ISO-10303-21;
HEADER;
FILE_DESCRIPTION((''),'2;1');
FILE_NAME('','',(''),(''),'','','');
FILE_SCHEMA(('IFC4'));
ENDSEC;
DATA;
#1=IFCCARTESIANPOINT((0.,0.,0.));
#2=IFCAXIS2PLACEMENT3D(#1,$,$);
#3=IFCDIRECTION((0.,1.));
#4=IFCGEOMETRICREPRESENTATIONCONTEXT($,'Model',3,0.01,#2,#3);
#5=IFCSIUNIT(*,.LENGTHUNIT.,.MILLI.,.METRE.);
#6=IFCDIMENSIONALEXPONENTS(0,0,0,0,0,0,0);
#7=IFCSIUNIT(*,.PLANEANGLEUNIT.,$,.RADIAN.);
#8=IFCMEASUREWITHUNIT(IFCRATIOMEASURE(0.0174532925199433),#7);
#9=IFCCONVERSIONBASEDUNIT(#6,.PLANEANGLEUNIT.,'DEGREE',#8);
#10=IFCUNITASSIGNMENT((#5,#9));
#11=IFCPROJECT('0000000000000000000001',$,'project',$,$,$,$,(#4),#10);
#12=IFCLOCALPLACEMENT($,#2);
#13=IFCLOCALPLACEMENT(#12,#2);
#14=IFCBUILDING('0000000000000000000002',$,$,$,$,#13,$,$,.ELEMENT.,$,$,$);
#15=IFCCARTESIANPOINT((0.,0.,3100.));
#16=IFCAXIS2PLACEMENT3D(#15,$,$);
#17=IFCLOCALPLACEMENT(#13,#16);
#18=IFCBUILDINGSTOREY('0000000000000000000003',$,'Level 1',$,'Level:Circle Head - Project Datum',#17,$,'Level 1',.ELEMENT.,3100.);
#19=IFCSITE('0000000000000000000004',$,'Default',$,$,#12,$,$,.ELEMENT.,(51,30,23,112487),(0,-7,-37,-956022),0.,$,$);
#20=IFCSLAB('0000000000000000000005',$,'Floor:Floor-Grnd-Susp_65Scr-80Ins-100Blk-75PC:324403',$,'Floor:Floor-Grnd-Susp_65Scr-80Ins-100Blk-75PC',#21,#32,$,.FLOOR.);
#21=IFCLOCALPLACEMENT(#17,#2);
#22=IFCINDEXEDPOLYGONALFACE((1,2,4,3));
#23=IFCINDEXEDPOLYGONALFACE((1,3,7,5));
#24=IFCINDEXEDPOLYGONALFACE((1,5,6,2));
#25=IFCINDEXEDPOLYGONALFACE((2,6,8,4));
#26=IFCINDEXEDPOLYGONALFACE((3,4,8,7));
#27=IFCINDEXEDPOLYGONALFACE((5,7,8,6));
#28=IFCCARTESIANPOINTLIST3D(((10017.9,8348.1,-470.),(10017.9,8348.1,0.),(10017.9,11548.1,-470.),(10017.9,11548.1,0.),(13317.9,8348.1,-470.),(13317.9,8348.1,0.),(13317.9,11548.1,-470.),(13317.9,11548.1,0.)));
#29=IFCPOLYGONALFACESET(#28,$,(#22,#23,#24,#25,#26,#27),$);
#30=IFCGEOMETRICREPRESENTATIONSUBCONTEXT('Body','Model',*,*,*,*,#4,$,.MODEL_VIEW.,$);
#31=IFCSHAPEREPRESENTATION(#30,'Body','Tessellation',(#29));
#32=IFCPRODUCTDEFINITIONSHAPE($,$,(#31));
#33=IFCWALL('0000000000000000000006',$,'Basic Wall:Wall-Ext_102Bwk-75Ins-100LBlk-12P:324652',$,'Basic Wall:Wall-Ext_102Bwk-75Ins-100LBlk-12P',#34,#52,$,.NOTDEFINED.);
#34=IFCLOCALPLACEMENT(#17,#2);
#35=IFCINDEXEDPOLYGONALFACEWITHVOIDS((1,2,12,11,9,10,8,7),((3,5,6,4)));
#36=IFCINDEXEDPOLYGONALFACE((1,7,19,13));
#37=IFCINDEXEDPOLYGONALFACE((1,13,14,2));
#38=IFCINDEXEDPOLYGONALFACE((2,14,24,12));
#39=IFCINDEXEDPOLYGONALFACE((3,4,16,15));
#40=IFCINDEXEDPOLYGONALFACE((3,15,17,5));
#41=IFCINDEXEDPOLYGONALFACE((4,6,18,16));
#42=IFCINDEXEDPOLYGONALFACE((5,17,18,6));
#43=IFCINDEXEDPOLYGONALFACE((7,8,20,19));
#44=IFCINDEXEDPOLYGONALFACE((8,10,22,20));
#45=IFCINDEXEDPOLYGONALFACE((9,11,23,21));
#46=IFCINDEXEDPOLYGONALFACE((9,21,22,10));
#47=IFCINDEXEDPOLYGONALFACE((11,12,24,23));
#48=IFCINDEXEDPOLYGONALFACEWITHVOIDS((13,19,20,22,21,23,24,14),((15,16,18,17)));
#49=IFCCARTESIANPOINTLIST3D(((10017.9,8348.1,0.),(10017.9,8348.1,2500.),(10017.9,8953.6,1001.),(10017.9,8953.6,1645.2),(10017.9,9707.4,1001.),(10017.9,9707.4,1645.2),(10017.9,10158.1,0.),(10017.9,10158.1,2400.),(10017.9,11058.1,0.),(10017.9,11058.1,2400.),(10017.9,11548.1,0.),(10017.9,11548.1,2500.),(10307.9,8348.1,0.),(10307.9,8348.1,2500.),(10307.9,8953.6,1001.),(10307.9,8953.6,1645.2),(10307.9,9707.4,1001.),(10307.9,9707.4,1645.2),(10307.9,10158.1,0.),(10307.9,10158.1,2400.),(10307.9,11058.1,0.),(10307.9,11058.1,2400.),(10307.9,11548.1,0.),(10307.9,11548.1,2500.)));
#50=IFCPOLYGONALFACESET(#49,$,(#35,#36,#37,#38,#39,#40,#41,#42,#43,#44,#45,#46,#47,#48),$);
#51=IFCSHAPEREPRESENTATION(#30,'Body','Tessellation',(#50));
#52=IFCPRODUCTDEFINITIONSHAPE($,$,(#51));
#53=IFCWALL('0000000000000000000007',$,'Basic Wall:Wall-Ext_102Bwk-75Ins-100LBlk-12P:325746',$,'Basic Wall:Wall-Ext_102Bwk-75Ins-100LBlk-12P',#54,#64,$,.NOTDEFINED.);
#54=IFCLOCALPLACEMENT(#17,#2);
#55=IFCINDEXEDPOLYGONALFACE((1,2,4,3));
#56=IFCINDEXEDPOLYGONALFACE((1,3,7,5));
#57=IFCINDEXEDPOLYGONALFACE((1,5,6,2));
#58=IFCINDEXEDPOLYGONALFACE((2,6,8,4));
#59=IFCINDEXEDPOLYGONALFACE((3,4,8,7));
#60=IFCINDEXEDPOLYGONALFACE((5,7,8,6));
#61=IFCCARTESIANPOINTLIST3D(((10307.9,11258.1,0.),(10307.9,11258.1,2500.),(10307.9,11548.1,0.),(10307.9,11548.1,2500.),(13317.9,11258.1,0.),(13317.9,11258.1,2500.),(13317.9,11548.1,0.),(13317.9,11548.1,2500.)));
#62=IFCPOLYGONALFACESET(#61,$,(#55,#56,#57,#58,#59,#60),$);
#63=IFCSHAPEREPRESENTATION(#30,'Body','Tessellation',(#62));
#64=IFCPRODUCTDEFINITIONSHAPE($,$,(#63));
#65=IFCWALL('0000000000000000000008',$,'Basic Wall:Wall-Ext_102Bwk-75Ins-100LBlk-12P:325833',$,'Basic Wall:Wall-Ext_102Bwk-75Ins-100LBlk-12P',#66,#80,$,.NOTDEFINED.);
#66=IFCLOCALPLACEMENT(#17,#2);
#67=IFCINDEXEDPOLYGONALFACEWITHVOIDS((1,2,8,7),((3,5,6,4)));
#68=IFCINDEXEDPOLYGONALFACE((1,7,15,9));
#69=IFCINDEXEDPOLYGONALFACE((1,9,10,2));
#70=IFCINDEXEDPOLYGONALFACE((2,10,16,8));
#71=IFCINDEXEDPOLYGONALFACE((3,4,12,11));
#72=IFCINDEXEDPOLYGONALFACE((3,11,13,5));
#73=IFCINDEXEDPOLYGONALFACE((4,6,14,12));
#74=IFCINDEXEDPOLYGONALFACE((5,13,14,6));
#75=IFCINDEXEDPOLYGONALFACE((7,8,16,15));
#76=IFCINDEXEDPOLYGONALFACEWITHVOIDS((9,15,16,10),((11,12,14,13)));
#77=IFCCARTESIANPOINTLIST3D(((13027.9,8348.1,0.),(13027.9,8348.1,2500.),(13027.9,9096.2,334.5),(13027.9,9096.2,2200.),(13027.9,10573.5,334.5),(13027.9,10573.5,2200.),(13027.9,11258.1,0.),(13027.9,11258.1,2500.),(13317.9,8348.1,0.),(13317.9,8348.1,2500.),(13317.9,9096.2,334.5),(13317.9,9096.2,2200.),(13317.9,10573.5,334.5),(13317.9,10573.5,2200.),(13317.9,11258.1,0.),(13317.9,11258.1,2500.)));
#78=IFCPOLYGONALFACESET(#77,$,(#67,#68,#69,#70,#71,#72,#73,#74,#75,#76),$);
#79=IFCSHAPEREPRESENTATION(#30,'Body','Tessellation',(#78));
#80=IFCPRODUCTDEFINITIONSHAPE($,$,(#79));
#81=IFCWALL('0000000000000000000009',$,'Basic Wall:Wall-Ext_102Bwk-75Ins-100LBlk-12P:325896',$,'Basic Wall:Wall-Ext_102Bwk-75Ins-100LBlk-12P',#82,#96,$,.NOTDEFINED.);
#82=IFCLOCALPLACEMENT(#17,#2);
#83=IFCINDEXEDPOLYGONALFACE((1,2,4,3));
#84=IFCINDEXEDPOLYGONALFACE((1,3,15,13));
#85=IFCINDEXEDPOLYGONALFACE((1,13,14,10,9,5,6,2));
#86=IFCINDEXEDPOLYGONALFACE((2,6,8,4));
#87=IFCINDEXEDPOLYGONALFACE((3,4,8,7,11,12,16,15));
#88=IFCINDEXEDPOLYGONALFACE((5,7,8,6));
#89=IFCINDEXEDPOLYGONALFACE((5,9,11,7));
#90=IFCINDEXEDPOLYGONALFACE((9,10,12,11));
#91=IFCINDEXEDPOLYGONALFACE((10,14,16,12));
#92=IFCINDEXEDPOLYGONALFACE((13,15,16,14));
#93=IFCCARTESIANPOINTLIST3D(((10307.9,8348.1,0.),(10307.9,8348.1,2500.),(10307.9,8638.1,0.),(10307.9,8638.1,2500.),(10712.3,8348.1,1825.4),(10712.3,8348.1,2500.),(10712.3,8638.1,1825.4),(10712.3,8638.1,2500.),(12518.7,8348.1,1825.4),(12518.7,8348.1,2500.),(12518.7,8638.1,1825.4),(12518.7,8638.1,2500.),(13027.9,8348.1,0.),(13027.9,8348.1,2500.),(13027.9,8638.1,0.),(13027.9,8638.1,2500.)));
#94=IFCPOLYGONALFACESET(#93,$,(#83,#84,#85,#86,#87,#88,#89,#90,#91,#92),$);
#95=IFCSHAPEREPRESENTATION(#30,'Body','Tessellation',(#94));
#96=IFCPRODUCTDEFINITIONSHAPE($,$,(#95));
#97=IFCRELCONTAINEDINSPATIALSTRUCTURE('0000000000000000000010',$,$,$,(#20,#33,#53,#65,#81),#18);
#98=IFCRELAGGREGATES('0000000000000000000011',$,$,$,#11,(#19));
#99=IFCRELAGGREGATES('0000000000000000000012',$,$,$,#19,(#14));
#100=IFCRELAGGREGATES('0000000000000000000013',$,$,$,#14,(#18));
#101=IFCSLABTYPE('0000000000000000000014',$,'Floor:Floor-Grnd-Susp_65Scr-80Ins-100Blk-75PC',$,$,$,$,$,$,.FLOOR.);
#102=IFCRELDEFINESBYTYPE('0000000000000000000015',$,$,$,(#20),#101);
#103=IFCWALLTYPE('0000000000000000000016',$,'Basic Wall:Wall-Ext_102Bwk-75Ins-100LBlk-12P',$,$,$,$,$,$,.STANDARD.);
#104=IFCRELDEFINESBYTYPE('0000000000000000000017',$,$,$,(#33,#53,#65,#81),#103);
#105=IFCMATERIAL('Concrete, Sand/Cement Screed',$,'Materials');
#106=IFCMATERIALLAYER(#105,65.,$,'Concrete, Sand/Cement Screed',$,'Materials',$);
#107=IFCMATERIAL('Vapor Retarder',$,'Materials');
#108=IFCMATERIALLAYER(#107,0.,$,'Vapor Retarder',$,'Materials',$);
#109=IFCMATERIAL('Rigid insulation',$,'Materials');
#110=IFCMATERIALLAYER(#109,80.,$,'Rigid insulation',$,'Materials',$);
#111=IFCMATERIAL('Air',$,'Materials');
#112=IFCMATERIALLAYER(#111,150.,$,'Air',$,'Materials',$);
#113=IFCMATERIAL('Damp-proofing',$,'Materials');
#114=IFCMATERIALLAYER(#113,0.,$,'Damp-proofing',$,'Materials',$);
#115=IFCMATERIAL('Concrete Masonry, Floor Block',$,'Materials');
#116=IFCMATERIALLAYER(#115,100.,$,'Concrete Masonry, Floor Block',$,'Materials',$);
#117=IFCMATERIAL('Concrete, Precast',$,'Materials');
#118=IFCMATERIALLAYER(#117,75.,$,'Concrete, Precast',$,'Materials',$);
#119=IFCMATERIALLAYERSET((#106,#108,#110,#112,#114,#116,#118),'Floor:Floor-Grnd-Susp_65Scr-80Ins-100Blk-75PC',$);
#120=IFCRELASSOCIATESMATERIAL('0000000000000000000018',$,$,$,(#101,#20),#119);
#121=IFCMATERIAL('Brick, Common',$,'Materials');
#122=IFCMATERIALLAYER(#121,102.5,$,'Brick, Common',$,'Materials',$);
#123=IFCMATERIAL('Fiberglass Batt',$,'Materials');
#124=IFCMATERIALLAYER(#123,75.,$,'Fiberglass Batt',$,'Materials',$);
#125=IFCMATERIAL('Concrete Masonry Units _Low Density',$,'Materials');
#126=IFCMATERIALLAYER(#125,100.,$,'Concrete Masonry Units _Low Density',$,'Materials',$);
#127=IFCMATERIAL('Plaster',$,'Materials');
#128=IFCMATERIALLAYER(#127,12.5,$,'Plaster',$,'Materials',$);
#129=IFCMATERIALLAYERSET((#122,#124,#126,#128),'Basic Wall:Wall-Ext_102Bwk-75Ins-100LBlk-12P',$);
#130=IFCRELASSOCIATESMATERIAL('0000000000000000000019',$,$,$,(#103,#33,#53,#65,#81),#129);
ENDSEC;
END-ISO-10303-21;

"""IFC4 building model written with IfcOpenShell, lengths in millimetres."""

from ifc_helpers import new_model, entity, si_unit, converted_unit, direction, frame, frame_2d, origin, origin_2d_with_axis, place, context, subcontext, project, spatial, rectangle, extrude, material, layer, layer_set, layer_usage, type_object, element, save


model = new_model("IFC4")

# Units and contexts
model_context = context("Model", 3, precision=0.01, world=origin(), true_north=direction((0.0, 1.0)))
body_context = subcontext(model_context, "Body", "Model", "MODEL_VIEW")
ifc_project = project(units=[si_unit("LENGTHUNIT", "METRE", prefix="MILLI"), converted_unit("PLANEANGLEUNIT", "DEGREE", entity("IfcRatioMeasure", 0.0174532925199433), si_unit("PLANEANGLEUNIT", "RADIAN"), dimensions=[0, 0, 0, 0, 0, 0, 0])], contexts=[model_context])

# Site, building, storey
site_placement = place(None, origin())
site = spatial("IfcSite", under=ifc_project, at=site_placement, Name="Default", CompositionType="ELEMENT", RefLatitude=(51, 30, 23, 112487), RefLongitude=(0, -7, -37, -956022), RefElevation=0.0)
building_placement = place(site_placement, origin())
building = spatial("IfcBuilding", under=site, at=building_placement, CompositionType="ELEMENT")
storey_placement = place(building_placement, frame((0.0, 0.0, 3100.0)))
storey = spatial("IfcBuildingStorey", under=building, at=storey_placement, Name="Level 1", ObjectType="Level:Circle Head - Project Datum", LongName="Level 1", CompositionType="ELEMENT", Elevation=3100.0)

# Slab
ifc_material_1 = material(Name="Concrete, Sand/Cement Screed", Category="Materials")
ifc_layer_1 = layer(ifc_material_1, 65.0, Name="Concrete, Sand/Cement Screed", Category="Materials")
ifc_material_2 = material(Name="Vapor Retarder", Category="Materials")
ifc_layer_2 = layer(ifc_material_2, 0.0, Name="Vapor Retarder", Category="Materials")
ifc_material_3 = material(Name="Rigid insulation", Category="Materials")
ifc_layer_3 = layer(ifc_material_3, 80.0, Name="Rigid insulation", Category="Materials")
ifc_material_4 = material(Name="Air", Category="Materials")
ifc_layer_4 = layer(ifc_material_4, 150.0, Name="Air", Category="Materials")
ifc_material_5 = material(Name="Damp-proofing", Category="Materials")
ifc_layer_5 = layer(ifc_material_5, 0.0, Name="Damp-proofing", Category="Materials")
ifc_material_6 = material(Name="Concrete Masonry, Floor Block", Category="Materials")
ifc_layer_6 = layer(ifc_material_6, 100.0, Name="Concrete Masonry, Floor Block", Category="Materials")
ifc_material_7 = material(Name="Concrete, Precast", Category="Materials")
ifc_layer_7 = layer(ifc_material_7, 75.0, Name="Concrete, Precast", Category="Materials")
ifc_layer_set_1 = layer_set([ifc_layer_1, ifc_layer_2, ifc_layer_3, ifc_layer_4, ifc_layer_5, ifc_layer_6, ifc_layer_7], Name="Floor:Floor-Grnd-Susp_65Scr-80Ins-100Blk-75PC")
ifc_layer_usage_1 = layer_usage(ifc_layer_set_1, "AXIS3", "POSITIVE", 0.0)
slab_type = type_object("IfcSlabType", Name="Floor:Floor-Grnd-Susp_65Scr-80Ins-100Blk-75PC", PredefinedType="FLOOR", material=ifc_layer_set_1)
slab_placement = place(storey_placement, origin())
element("IfcSlab", 1, at=slab_placement, inside=storey, type_object=slab_type, material=ifc_layer_usage_1, Name="Floor:Floor-Grnd-Susp_65Scr-80Ins-100Blk-75PC:324403", ObjectType="Floor:Floor-Grnd-Susp_65Scr-80Ins-100Blk-75PC", PredefinedType="FLOOR", context=body_context, shape_type="SweptSolid", body=[
    extrude(rectangle(XDim=3200.0, YDim=3300.0, at=origin_2d_with_axis()), frame((11667.9, 9948.1, 0.0), z_axis=(0.0, 0.0, -1.0), x_axis=(0.0, 1.0, 0.0)), (0.0, 0.0, 1.0), 470.0),
])

# Wall, openings
ifc_material_8 = material(Name="Brick, Common", Category="Materials")
ifc_layer_8 = layer(ifc_material_8, 102.5, Name="Brick, Common", Category="Materials")
ifc_material_9 = material(Name="Fiberglass Batt", Category="Materials")
ifc_layer_9 = layer(ifc_material_9, 75.0, Name="Fiberglass Batt", Category="Materials")
ifc_material_10 = material(Name="Concrete Masonry Units _Low Density", Category="Materials")
ifc_layer_10 = layer(ifc_material_10, 100.0, Name="Concrete Masonry Units _Low Density", Category="Materials")
ifc_material_11 = material(Name="Plaster", Category="Materials")
ifc_layer_11 = layer(ifc_material_11, 12.5, Name="Plaster", Category="Materials")
ifc_layer_set_2 = layer_set([ifc_layer_8, ifc_layer_9, ifc_layer_10, ifc_layer_11], Name="Basic Wall:Wall-Ext_102Bwk-75Ins-100LBlk-12P")
ifc_layer_usage_2 = layer_usage(ifc_layer_set_2, "AXIS2", "NEGATIVE", 145.0)
wall_type = type_object("IfcWallType", Name="Basic Wall:Wall-Ext_102Bwk-75Ins-100LBlk-12P", PredefinedType="STANDARD", material=ifc_layer_set_2)
wall_1_placement = place(storey_placement, frame((10162.9, 8348.1, 0.0), z_axis=(0.0, 0.0, 1.0), x_axis=(0.0, 1.0, 0.0)))
wall_1 = element("IfcWall", 2, at=wall_1_placement, inside=storey, type_object=wall_type, material=ifc_layer_usage_2, Name="Basic Wall:Wall-Ext_102Bwk-75Ins-100LBlk-12P:324652", ObjectType="Basic Wall:Wall-Ext_102Bwk-75Ins-100LBlk-12P", PredefinedType="NOTDEFINED", context=body_context, shape_type="SweptSolid", body=[
    extrude(rectangle(XDim=3200.0, YDim=290.0, at=frame_2d((1600.0, 0.0), x_axis=(-1.0, 0.0))), origin(), (0.0, 0.0, 1.0), 2500.0),
])
opening_1_placement = place(wall_1_placement, frame((1810.0, 145.0, 0.0)))
element("IfcOpeningElement", 3, at=opening_1_placement, cuts=wall_1, PredefinedType="OPENING", context=body_context, shape_type="SweptSolid", body=[
    extrude(rectangle(XDim=2400.0, YDim=900.0, at=frame_2d((0.0, 0.0), x_axis=(1.0, 0.0))), frame((450.0, -290.0, 1200.0), z_axis=(0.0, 1.0, 0.0), x_axis=(0.0, 0.0, -1.0)), (0.0, 0.0, 1.0), 290.0),
])
opening_2_placement = place(wall_1_placement, frame((605.5, 145.0, 1001.0)))
element("IfcOpeningElement", 4, at=opening_2_placement, cuts=wall_1, PredefinedType="OPENING", context=body_context, shape_type="SweptSolid", body=[
    extrude(rectangle(XDim=644.2, YDim=753.8, at=origin_2d_with_axis()), frame((376.9, -290.0, 322.1), z_axis=(0.0, 1.0, 0.0), x_axis=(0.0, 0.0, -1.0)), (0.0, 0.0, 1.0), 290.0),
])

# Wall
ifc_layer_usage_3 = layer_usage(ifc_layer_set_2, "AXIS2", "NEGATIVE", 145.0)
wall_2_placement = place(storey_placement, frame((10307.9, 11403.1, 0.0)))
element("IfcWall", 5, at=wall_2_placement, inside=storey, type_object=wall_type, material=ifc_layer_usage_3, Name="Basic Wall:Wall-Ext_102Bwk-75Ins-100LBlk-12P:325746", ObjectType="Basic Wall:Wall-Ext_102Bwk-75Ins-100LBlk-12P", PredefinedType="NOTDEFINED", context=body_context, shape_type="SweptSolid", body=[
    extrude(rectangle(XDim=3010.0, YDim=290.0, at=frame_2d((1505.0, 0.0), x_axis=(-1.0, 0.0))), origin(), (0.0, 0.0, 1.0), 2500.0),
])

# Walls, openings
ifc_layer_usage_4 = layer_usage(ifc_layer_set_2, "AXIS2", "NEGATIVE", 145.0)
wall_3_placement = place(storey_placement, frame((13172.9, 11258.1, 0.0), z_axis=(0.0, 0.0, 1.0), x_axis=(0.0, -1.0, 0.0)))
wall_3 = element("IfcWall", 6, at=wall_3_placement, inside=storey, type_object=wall_type, material=ifc_layer_usage_4, Name="Basic Wall:Wall-Ext_102Bwk-75Ins-100LBlk-12P:325833", ObjectType="Basic Wall:Wall-Ext_102Bwk-75Ins-100LBlk-12P", PredefinedType="NOTDEFINED", context=body_context, shape_type="SweptSolid", body=[
    extrude(rectangle(XDim=2910.0, YDim=290.0, at=frame_2d((1455.0, 0.0), x_axis=(-1.0, 0.0))), origin(), (0.0, 0.0, 1.0), 2500.0),
])
opening_3_placement = place(wall_3_placement, frame((2161.9, -145.0, 334.5)))
element("IfcOpeningElement", 7, at=opening_3_placement, cuts=wall_3, PredefinedType="OPENING", context=body_context, shape_type="SweptSolid", body=[
    extrude(rectangle(XDim=1865.5, YDim=1477.4, at=origin_2d_with_axis()), frame((-738.7, 0.0, 932.8), z_axis=(0.0, 1.0, 0.0), x_axis=(0.0, 0.0, -1.0)), (0.0, 0.0, 1.0), 290.0),
])
ifc_layer_usage_5 = layer_usage(ifc_layer_set_2, "AXIS2", "NEGATIVE", 145.0)
wall_4_placement = place(storey_placement, frame((13027.9, 8493.1, 0.0), z_axis=(0.0, 0.0, 1.0), x_axis=(-1.0, 0.0, 0.0)))
wall_4 = element("IfcWall", 8, at=wall_4_placement, inside=storey, type_object=wall_type, material=ifc_layer_usage_5, Name="Basic Wall:Wall-Ext_102Bwk-75Ins-100LBlk-12P:325896", ObjectType="Basic Wall:Wall-Ext_102Bwk-75Ins-100LBlk-12P", PredefinedType="NOTDEFINED", context=body_context, shape_type="SweptSolid", body=[
    extrude(rectangle(XDim=2720.0, YDim=290.0, at=frame_2d((1360.0, 0.0), x_axis=(-1.0, 0.0))), origin(), (0.0, 0.0, 1.0), 2500.0),
])
opening_4_placement = place(wall_4_placement, frame((2315.6, 145.0, 1825.4)))
element("IfcOpeningElement", 9, at=opening_4_placement, cuts=wall_4, PredefinedType="OPENING", context=body_context, shape_type="SweptSolid", body=[
    extrude(rectangle(XDim=690.4, YDim=1806.3, at=frame_2d((0.0, 0.0), x_axis=(1.0, 0.0))), frame((-903.2, -290.0, 345.2), z_axis=(0.0, 1.0, 0.0), x_axis=(0.0, 0.0, -1.0)), (0.0, 0.0, 1.0), 290.0),
])

save(model, "model.ifc")
